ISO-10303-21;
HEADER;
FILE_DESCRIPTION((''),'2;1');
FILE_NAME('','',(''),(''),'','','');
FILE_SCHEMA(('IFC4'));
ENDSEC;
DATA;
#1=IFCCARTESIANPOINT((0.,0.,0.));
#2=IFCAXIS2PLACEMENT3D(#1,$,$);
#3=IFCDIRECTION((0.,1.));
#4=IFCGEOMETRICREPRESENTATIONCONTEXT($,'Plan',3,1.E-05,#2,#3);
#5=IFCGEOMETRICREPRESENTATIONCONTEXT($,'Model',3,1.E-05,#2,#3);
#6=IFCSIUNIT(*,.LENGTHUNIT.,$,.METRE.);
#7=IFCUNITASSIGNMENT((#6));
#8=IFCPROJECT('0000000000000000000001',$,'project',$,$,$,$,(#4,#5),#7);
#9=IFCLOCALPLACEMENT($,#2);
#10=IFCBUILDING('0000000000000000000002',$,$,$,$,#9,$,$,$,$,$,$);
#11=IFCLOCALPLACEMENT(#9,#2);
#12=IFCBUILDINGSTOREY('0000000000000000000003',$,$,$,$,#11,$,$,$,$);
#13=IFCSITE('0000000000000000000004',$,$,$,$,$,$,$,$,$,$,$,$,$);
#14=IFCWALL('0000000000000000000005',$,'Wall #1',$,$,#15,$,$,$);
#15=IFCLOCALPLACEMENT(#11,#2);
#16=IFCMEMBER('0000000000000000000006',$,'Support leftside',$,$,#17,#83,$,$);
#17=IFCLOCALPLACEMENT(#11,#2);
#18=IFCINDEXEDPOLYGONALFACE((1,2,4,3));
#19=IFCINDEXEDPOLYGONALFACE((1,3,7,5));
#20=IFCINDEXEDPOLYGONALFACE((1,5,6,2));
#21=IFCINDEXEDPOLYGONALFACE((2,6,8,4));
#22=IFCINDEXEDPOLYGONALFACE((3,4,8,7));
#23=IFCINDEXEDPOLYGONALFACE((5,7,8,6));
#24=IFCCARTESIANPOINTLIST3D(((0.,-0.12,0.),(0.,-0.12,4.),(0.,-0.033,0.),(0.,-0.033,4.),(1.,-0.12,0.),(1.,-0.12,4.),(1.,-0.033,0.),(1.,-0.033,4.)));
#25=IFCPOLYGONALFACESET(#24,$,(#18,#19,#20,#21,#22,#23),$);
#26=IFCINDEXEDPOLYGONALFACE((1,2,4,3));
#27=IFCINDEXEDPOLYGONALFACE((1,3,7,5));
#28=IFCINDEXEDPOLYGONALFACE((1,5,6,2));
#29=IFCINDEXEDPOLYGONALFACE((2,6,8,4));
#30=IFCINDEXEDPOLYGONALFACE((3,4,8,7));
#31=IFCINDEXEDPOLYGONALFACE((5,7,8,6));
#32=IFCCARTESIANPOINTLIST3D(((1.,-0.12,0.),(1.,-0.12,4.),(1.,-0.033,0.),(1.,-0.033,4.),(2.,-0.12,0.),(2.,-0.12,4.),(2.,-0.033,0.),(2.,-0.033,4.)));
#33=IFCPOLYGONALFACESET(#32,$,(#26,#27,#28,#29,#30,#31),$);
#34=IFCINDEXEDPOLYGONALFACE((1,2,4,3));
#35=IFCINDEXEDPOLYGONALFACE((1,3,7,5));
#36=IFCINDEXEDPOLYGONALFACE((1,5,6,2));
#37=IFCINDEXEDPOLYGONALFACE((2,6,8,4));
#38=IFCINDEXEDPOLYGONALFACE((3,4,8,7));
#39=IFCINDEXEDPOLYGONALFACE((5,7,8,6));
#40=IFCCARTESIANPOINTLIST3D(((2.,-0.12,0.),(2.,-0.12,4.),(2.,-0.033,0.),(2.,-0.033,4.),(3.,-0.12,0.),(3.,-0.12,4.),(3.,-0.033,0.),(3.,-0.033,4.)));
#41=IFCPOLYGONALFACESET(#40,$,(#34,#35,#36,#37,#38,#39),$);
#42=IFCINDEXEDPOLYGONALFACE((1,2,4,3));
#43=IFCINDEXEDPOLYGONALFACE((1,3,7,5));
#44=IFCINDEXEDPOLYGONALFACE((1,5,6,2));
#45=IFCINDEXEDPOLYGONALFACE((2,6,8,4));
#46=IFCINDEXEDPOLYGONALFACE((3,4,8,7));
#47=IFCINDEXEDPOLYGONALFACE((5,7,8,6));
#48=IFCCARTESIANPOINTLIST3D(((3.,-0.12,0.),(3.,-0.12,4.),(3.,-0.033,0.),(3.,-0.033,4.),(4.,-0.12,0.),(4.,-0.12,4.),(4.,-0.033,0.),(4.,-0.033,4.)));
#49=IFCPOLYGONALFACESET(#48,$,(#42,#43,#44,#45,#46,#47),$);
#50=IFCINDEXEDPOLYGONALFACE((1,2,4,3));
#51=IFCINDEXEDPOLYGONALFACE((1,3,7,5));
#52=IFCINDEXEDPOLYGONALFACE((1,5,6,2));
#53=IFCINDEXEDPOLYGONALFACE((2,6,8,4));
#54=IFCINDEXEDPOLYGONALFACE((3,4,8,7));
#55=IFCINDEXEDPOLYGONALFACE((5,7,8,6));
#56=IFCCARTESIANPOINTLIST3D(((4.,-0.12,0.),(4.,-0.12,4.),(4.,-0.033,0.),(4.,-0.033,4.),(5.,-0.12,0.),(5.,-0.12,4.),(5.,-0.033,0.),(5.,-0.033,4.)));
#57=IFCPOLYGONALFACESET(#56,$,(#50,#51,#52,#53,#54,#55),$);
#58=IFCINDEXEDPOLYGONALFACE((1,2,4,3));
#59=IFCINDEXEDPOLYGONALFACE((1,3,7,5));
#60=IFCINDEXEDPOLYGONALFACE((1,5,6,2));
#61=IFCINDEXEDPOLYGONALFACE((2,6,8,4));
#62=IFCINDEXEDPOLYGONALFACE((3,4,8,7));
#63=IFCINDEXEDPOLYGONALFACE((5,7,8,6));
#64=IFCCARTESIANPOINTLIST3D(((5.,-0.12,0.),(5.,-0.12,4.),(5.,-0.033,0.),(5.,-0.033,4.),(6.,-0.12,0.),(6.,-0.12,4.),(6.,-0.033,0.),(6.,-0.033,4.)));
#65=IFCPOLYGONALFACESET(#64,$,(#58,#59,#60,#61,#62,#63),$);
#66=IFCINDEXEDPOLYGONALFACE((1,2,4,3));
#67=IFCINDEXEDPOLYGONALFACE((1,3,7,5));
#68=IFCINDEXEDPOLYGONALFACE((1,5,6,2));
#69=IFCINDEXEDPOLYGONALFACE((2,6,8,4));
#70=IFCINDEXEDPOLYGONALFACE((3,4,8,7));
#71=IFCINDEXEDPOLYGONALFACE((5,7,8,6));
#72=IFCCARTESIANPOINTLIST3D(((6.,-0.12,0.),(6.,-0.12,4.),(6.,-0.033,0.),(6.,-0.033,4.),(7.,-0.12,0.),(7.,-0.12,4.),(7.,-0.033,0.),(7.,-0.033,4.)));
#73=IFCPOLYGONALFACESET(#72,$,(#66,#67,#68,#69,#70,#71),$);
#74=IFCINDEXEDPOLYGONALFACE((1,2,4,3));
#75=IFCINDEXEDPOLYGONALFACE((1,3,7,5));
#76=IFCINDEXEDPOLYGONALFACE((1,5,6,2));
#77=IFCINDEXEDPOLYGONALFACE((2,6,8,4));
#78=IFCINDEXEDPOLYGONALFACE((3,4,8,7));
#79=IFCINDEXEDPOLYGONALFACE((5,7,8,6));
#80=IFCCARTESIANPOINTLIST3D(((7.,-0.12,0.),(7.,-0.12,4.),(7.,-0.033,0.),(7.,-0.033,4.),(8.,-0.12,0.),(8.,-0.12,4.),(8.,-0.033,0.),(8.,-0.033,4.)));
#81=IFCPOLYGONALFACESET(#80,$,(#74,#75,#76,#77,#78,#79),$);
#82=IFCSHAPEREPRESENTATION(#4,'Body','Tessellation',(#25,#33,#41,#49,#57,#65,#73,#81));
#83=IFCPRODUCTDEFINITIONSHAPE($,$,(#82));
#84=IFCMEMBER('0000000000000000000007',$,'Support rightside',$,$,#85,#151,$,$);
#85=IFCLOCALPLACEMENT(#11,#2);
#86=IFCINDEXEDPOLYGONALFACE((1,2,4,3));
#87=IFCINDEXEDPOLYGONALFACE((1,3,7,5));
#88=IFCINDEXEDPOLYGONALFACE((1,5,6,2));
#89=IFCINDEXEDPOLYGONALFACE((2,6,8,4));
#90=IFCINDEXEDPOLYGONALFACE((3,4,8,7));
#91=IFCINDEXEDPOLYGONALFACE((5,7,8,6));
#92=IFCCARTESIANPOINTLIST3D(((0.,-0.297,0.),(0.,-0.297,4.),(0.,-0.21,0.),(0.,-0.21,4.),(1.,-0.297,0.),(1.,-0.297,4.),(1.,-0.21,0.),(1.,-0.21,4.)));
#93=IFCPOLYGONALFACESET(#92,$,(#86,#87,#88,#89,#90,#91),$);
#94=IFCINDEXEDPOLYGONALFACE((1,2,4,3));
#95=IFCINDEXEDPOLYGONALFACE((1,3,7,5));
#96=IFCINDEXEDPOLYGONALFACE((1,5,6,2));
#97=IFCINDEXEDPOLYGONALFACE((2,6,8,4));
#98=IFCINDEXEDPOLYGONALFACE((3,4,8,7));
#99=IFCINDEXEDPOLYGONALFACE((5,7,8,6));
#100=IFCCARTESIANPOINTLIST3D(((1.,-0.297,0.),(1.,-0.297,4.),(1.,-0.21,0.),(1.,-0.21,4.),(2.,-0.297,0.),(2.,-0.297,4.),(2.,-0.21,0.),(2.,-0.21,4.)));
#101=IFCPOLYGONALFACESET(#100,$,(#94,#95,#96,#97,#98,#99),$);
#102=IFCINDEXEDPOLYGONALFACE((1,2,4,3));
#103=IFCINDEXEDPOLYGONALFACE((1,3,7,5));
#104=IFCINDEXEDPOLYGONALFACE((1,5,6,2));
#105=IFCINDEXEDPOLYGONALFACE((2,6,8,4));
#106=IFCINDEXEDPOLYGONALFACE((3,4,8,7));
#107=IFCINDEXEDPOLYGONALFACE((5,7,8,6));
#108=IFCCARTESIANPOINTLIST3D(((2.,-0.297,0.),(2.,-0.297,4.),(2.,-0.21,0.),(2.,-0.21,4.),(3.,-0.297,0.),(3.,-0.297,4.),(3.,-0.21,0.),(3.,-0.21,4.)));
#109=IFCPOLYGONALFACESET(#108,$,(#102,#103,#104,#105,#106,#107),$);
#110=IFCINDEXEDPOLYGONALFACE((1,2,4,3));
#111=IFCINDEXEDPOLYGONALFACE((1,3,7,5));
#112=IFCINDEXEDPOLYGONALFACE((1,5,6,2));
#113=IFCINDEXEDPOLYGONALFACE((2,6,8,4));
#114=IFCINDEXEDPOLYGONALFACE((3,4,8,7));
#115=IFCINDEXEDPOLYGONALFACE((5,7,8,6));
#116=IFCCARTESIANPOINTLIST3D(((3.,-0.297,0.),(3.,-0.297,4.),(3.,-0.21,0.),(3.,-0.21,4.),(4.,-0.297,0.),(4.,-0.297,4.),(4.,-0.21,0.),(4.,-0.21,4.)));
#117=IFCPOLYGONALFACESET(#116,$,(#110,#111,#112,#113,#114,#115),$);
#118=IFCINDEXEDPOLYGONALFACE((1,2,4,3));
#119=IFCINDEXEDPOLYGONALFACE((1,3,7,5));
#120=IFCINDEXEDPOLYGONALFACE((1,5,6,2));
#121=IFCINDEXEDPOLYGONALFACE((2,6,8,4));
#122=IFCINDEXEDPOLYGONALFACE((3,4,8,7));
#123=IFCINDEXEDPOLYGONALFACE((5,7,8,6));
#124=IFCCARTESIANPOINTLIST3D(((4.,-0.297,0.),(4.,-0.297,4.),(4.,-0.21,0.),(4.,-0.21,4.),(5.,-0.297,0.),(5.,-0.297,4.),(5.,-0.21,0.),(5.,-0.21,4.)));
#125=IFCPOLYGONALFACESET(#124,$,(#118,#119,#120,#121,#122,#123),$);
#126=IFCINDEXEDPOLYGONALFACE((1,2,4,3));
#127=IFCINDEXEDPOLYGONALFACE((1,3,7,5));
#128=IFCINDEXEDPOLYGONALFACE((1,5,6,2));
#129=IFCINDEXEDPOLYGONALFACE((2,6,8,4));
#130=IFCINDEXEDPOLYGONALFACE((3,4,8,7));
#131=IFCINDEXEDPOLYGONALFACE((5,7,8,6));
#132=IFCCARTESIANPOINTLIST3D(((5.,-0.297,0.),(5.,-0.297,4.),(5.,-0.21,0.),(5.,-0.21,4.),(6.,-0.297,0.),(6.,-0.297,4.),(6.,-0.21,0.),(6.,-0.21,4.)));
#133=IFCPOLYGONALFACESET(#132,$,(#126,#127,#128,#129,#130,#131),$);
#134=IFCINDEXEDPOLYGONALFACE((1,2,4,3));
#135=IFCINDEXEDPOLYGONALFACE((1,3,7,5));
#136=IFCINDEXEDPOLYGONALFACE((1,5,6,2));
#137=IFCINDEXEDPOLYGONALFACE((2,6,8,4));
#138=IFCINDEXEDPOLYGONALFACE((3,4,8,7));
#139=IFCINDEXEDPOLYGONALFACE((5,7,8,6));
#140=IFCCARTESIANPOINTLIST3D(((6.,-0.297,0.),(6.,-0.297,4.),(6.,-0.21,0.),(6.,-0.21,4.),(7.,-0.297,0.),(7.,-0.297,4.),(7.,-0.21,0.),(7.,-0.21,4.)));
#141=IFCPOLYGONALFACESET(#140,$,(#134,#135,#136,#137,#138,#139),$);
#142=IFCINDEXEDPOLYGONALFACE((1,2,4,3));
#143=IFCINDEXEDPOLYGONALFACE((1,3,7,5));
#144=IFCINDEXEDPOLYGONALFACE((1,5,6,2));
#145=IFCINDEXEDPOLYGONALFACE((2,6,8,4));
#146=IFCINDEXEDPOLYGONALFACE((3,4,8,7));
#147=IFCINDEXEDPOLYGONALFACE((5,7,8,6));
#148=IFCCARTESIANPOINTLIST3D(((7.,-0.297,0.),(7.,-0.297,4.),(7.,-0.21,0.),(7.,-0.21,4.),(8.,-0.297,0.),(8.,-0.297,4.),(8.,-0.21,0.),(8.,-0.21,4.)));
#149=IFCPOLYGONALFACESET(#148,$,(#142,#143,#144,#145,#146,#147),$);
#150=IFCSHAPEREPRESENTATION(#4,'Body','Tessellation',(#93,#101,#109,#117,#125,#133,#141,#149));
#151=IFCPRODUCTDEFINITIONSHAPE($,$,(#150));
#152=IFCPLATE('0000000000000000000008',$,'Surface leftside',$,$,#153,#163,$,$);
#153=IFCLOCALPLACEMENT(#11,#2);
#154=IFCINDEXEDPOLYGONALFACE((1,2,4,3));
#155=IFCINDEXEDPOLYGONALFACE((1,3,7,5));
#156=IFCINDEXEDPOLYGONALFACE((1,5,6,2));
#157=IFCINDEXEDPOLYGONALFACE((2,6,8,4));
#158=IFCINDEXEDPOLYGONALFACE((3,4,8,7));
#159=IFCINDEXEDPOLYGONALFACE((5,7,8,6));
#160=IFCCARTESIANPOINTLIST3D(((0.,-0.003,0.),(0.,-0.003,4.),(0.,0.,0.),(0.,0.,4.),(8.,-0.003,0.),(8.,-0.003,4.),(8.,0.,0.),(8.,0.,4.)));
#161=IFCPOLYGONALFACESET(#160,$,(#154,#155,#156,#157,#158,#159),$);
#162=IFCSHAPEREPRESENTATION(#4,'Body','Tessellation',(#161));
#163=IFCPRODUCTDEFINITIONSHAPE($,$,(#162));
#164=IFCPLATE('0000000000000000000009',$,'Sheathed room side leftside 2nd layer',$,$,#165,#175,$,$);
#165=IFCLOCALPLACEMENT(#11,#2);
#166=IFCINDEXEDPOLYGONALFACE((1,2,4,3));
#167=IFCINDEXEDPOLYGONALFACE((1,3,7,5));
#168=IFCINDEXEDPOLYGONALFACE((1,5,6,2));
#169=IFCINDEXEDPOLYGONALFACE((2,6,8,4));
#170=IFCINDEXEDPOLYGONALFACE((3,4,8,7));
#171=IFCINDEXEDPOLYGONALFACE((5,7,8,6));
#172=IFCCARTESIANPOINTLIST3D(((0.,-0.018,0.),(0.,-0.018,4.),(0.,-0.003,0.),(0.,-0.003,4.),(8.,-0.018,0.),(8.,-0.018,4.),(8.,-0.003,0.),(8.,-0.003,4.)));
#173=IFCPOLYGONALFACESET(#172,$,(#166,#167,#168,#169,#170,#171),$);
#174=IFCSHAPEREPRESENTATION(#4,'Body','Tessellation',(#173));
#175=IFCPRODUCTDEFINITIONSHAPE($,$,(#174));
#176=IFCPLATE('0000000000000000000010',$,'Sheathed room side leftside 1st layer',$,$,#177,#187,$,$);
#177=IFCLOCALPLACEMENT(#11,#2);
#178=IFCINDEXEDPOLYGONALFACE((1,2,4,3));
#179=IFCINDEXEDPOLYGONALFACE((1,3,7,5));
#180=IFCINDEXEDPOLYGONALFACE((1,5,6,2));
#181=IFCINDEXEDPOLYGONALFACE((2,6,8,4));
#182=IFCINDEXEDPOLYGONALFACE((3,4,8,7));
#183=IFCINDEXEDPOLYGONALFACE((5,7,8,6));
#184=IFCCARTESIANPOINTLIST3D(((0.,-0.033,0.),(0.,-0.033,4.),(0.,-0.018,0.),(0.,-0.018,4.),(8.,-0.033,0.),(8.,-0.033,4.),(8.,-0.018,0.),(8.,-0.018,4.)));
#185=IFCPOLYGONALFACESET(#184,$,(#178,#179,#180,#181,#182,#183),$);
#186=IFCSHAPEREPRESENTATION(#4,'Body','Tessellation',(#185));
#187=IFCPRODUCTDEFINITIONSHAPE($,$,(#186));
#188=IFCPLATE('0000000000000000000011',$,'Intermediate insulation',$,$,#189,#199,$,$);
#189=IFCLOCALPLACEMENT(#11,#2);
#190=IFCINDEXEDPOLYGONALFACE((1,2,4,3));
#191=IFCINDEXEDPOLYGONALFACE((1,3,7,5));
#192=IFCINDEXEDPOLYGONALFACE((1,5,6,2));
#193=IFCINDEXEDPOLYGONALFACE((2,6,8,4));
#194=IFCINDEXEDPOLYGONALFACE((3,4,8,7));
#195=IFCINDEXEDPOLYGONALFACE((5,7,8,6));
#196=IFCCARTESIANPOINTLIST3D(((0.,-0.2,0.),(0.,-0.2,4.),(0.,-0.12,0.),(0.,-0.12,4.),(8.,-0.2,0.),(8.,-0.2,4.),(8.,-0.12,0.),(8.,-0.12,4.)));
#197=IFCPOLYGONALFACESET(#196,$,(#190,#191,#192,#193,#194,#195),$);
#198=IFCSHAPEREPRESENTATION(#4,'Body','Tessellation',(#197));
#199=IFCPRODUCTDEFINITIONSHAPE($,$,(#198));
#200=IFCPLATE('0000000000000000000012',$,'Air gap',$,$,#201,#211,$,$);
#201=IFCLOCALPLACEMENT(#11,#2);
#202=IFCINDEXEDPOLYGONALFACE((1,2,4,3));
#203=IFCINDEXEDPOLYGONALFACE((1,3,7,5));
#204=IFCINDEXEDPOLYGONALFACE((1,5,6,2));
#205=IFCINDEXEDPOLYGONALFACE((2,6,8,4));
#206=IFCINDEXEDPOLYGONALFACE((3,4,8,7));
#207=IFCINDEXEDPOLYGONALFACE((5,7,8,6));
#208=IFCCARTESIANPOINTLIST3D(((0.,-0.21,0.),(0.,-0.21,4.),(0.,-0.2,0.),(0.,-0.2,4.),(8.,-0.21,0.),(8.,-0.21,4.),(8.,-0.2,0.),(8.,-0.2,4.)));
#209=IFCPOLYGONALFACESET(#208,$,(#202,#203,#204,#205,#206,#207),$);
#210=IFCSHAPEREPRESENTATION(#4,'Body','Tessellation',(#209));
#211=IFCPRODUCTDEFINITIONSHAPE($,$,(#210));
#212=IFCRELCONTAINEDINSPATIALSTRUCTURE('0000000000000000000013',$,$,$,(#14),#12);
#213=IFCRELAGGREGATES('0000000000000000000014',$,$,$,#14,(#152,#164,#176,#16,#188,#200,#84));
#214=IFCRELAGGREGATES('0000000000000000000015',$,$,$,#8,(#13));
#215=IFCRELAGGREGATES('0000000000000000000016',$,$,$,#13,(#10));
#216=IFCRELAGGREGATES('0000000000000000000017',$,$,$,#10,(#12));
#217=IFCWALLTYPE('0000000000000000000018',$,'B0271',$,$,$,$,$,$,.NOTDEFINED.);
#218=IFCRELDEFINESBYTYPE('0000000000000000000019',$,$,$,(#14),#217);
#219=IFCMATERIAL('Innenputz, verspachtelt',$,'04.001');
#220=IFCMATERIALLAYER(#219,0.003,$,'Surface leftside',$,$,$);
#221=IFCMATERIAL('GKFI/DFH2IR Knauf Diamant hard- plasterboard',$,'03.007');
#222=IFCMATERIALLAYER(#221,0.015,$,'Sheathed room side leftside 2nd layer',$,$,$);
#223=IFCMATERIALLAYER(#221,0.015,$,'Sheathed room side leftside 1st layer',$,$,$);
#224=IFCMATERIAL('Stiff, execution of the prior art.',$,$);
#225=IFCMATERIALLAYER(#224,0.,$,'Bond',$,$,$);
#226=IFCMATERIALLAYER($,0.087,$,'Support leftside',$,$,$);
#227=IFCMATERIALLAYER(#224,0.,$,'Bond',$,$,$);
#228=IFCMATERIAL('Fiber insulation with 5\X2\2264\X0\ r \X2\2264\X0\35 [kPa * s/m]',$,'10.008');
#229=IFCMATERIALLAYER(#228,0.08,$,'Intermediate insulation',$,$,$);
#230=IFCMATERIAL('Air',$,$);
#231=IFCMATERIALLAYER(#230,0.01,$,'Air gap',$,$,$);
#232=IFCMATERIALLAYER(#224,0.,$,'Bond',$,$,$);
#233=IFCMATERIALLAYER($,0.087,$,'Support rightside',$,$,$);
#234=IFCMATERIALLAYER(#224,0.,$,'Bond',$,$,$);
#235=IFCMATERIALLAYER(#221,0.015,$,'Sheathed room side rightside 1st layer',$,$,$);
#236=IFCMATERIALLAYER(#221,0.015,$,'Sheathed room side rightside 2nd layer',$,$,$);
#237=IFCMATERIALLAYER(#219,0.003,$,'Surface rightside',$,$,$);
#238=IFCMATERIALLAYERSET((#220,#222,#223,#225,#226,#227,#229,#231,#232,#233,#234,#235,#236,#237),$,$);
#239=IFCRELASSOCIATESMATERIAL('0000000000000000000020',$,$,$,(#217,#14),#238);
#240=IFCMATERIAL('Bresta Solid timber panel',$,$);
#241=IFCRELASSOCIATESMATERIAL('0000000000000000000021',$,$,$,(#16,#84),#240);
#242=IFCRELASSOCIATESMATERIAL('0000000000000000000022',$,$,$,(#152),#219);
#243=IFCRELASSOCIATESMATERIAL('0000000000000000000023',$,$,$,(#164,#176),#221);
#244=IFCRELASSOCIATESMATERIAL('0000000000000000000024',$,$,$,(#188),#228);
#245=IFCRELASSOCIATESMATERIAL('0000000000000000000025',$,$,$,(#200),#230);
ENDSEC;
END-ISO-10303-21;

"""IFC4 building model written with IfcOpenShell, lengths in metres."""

from ifc_helpers import new_model, si_unit, direction, frame, frame_2d, origin, origin_with_axes, place, context, project, spatial, rectangle, extrude, material, layer, layer_set, type_object, element, aggregate, save


model = new_model("IFC4")

# Units and contexts
plan_context = context("Plan", 3, precision=1e-05, world=origin(), true_north=direction((0.0, 1.0)))
model_context = context("Model", 3, precision=1e-05, world=origin(), true_north=direction((0.0, 1.0)))
ifc_project = project(units=[si_unit("LENGTHUNIT", "METRE")], contexts=[plan_context, model_context])

# Site, building, storey
site = spatial("IfcSite", under=ifc_project)
building_placement = place(None, origin())
building = spatial("IfcBuilding", under=site, at=building_placement)
storey_placement = place(building_placement, origin())
storey = spatial("IfcBuildingStorey", under=building, at=storey_placement)

# Wall, members, plates
ifc_material_1 = material(Name="Innenputz, verspachtelt", Category="04.001")
ifc_layer_1 = layer(ifc_material_1, 0.003, Name="Surface leftside")
ifc_material_2 = material(Name="GKFI/DFH2IR Knauf Diamant hard- plasterboard", Category="03.007")
ifc_layer_2 = layer(ifc_material_2, 0.015, Name="Sheathed room side leftside 2nd layer")
ifc_layer_3 = layer(ifc_material_2, 0.015, Name="Sheathed room side leftside 1st layer")
ifc_material_3 = material(Name="Stiff, execution of the prior art.")
ifc_layer_4 = layer(ifc_material_3, 0.0, Name="Bond")
ifc_layer_5 = layer(None, 0.087, Name="Support leftside")
ifc_layer_6 = layer(ifc_material_3, 0.0, Name="Bond")
ifc_material_4 = material(Name="Fiber insulation with 5≤ r ≤35 [kPa * s/m]", Category="10.008")
ifc_layer_7 = layer(ifc_material_4, 0.08, Name="Intermediate insulation")
ifc_material_5 = material(Name="Air")
ifc_layer_8 = layer(ifc_material_5, 0.01, Name="Air gap")
ifc_layer_9 = layer(ifc_material_3, 0.0, Name="Bond")
ifc_layer_10 = layer(None, 0.087, Name="Support rightside")
ifc_layer_11 = layer(ifc_material_3, 0.0, Name="Bond")
ifc_layer_12 = layer(ifc_material_2, 0.015, Name="Sheathed room side rightside 1st layer")
ifc_layer_13 = layer(ifc_material_2, 0.015, Name="Sheathed room side rightside 2nd layer")
ifc_layer_14 = layer(ifc_material_1, 0.003, Name="Surface rightside")
ifc_layer_set = layer_set([ifc_layer_1, ifc_layer_2, ifc_layer_3, ifc_layer_4, ifc_layer_5, ifc_layer_6, ifc_layer_7, ifc_layer_8, ifc_layer_9, ifc_layer_10, ifc_layer_11, ifc_layer_12, ifc_layer_13, ifc_layer_14])
wall_type = type_object("IfcWallType", Name="B0271", PredefinedType="NOTDEFINED", material=ifc_layer_set)
wall_placement = place(None, frame((0.0, 0.0, 0.0), z_axis=(0.0, -1.0, 0.0), x_axis=(1.0, 0.0, 0.0)))
wall = element("IfcWall", 1, at=wall_placement, inside=storey, type_object=wall_type, material=ifc_layer_set, Name="Wall #1")
ifc_material_6 = material(Name="Bresta Solid timber panel")
member_1_placement = place(wall_placement, origin())
member_1 = element("IfcMember", 2, at=member_1_placement, material=ifc_material_6, Name="Support leftside", context=plan_context, shape_type="SweptSolid", body=[
    extrude(rectangle(XDim=1.0, YDim=0.087, at=frame_2d((0.5, 0.0435), x_axis=(1.0, 0.0))), frame((0.0, 4.0, 0.033), z_axis=(0.0, -1.0, 0.0), x_axis=(1.0, 0.0, 0.0)), (0.0, 0.0, 1.0), 4.0),
    extrude(rectangle(XDim=1.0, YDim=0.087, at=frame_2d((0.5, 0.0435), x_axis=(1.0, 0.0))), frame((1.0, 4.0, 0.033), z_axis=(0.0, -1.0, 0.0), x_axis=(1.0, 0.0, 0.0)), (0.0, 0.0, 1.0), 4.0),
    extrude(rectangle(XDim=1.0, YDim=0.087, at=frame_2d((0.5, 0.0435), x_axis=(1.0, 0.0))), frame((2.0, 4.0, 0.033), z_axis=(0.0, -1.0, 0.0), x_axis=(1.0, 0.0, 0.0)), (0.0, 0.0, 1.0), 4.0),
    extrude(rectangle(XDim=1.0, YDim=0.087, at=frame_2d((0.5, 0.0435), x_axis=(1.0, 0.0))), frame((3.0, 4.0, 0.033), z_axis=(0.0, -1.0, 0.0), x_axis=(1.0, 0.0, 0.0)), (0.0, 0.0, 1.0), 4.0),
    extrude(rectangle(XDim=1.0, YDim=0.087, at=frame_2d((0.5, 0.0435), x_axis=(1.0, 0.0))), frame((4.0, 4.0, 0.033), z_axis=(0.0, -1.0, 0.0), x_axis=(1.0, 0.0, 0.0)), (0.0, 0.0, 1.0), 4.0),
    extrude(rectangle(XDim=1.0, YDim=0.087, at=frame_2d((0.5, 0.0435), x_axis=(1.0, 0.0))), frame((5.0, 4.0, 0.033), z_axis=(0.0, -1.0, 0.0), x_axis=(1.0, 0.0, 0.0)), (0.0, 0.0, 1.0), 4.0),
    extrude(rectangle(XDim=1.0, YDim=0.087, at=frame_2d((0.5, 0.0435), x_axis=(1.0, 0.0))), frame((6.0, 4.0, 0.033), z_axis=(0.0, -1.0, 0.0), x_axis=(1.0, 0.0, 0.0)), (0.0, 0.0, 1.0), 4.0),
    extrude(rectangle(XDim=1.0, YDim=0.087, at=frame_2d((0.5, 0.0435), x_axis=(1.0, 0.0))), frame((7.0, 4.0, 0.033), z_axis=(0.0, -1.0, 0.0), x_axis=(1.0, 0.0, 0.0)), (0.0, 0.0, 1.0), 4.0),
])
member_2_placement = place(wall_placement, origin())
member_2 = element("IfcMember", 3, at=member_2_placement, material=ifc_material_6, Name="Support rightside", context=plan_context, shape_type="SweptSolid", body=[
    extrude(rectangle(XDim=1.0, YDim=0.087, at=frame_2d((0.5, 0.0435), x_axis=(1.0, 0.0))), frame((0.0, 4.0, 0.21), z_axis=(0.0, -1.0, 0.0), x_axis=(1.0, 0.0, 0.0)), (0.0, 0.0, 1.0), 4.0),
    extrude(rectangle(XDim=1.0, YDim=0.087, at=frame_2d((0.5, 0.0435), x_axis=(1.0, 0.0))), frame((1.0, 4.0, 0.21), z_axis=(0.0, -1.0, 0.0), x_axis=(1.0, 0.0, 0.0)), (0.0, 0.0, 1.0), 4.0),
    extrude(rectangle(XDim=1.0, YDim=0.087, at=frame_2d((0.5, 0.0435), x_axis=(1.0, 0.0))), frame((2.0, 4.0, 0.21), z_axis=(0.0, -1.0, 0.0), x_axis=(1.0, 0.0, 0.0)), (0.0, 0.0, 1.0), 4.0),
    extrude(rectangle(XDim=1.0, YDim=0.087, at=frame_2d((0.5, 0.0435), x_axis=(1.0, 0.0))), frame((3.0, 4.0, 0.21), z_axis=(0.0, -1.0, 0.0), x_axis=(1.0, 0.0, 0.0)), (0.0, 0.0, 1.0), 4.0),
    extrude(rectangle(XDim=1.0, YDim=0.087, at=frame_2d((0.5, 0.0435), x_axis=(1.0, 0.0))), frame((4.0, 4.0, 0.21), z_axis=(0.0, -1.0, 0.0), x_axis=(1.0, 0.0, 0.0)), (0.0, 0.0, 1.0), 4.0),
    extrude(rectangle(XDim=1.0, YDim=0.087, at=frame_2d((0.5, 0.0435), x_axis=(1.0, 0.0))), frame((5.0, 4.0, 0.21), z_axis=(0.0, -1.0, 0.0), x_axis=(1.0, 0.0, 0.0)), (0.0, 0.0, 1.0), 4.0),
    extrude(rectangle(XDim=1.0, YDim=0.087, at=frame_2d((0.5, 0.0435), x_axis=(1.0, 0.0))), frame((6.0, 4.0, 0.21), z_axis=(0.0, -1.0, 0.0), x_axis=(1.0, 0.0, 0.0)), (0.0, 0.0, 1.0), 4.0),
    extrude(rectangle(XDim=1.0, YDim=0.087, at=frame_2d((0.5, 0.0435), x_axis=(1.0, 0.0))), frame((7.0, 4.0, 0.21), z_axis=(0.0, -1.0, 0.0), x_axis=(1.0, 0.0, 0.0)), (0.0, 0.0, 1.0), 4.0),
])
plate_1_placement = place(wall_placement, origin())
plate_1 = element("IfcPlate", 4, at=plate_1_placement, material=ifc_material_1, Name="Surface leftside", context=plan_context, shape_type="SweptSolid", body=[
    extrude(rectangle(XDim=8.0, YDim=4.0, at=frame_2d((4.0, 2.0), x_axis=(1.0, 0.0))), origin_with_axes(), (0.0, 0.0, 1.0), 0.003),
])
plate_2_placement = place(wall_placement, origin())
plate_2 = element("IfcPlate", 5, at=plate_2_placement, material=ifc_material_2, Name="Sheathed room side leftside 2nd layer", context=plan_context, shape_type="SweptSolid", body=[
    extrude(rectangle(XDim=8.0, YDim=4.0, at=frame_2d((4.0, 2.0), x_axis=(1.0, 0.0))), frame((0.0, 0.0, 0.003), z_axis=(0.0, 0.0, 1.0), x_axis=(1.0, 0.0, 0.0)), (0.0, 0.0, 1.0), 0.015),
])
plate_3_placement = place(wall_placement, origin())
plate_3 = element("IfcPlate", 6, at=plate_3_placement, material=ifc_material_2, Name="Sheathed room side leftside 1st layer", context=plan_context, shape_type="SweptSolid", body=[
    extrude(rectangle(XDim=8.0, YDim=4.0, at=frame_2d((4.0, 2.0), x_axis=(1.0, 0.0))), frame((0.0, 0.0, 0.018), z_axis=(0.0, 0.0, 1.0), x_axis=(1.0, 0.0, 0.0)), (0.0, 0.0, 1.0), 0.015),
])
plate_4_placement = place(wall_placement, origin())
plate_4 = element("IfcPlate", 7, at=plate_4_placement, material=ifc_material_4, Name="Intermediate insulation", context=plan_context, shape_type="SweptSolid", body=[
    extrude(rectangle(XDim=8.0, YDim=4.0, at=frame_2d((4.0, 2.0), x_axis=(1.0, 0.0))), frame((0.0, 0.0, 0.12), z_axis=(0.0, 0.0, 1.0), x_axis=(1.0, 0.0, 0.0)), (0.0, 0.0, 1.0), 0.08),
])
plate_5_placement = place(wall_placement, origin())
plate_5 = element("IfcPlate", 8, at=plate_5_placement, material=ifc_material_5, Name="Air gap", context=plan_context, shape_type="SweptSolid", body=[
    extrude(rectangle(XDim=8.0, YDim=4.0, at=frame_2d((4.0, 2.0), x_axis=(1.0, 0.0))), frame((0.0, 0.0, 0.2), z_axis=(0.0, 0.0, 1.0), x_axis=(1.0, 0.0, 0.0)), (0.0, 0.0, 1.0), 0.01),
])
aggregate(wall, [plate_1, plate_2, plate_3, member_1, plate_4, plate_5, member_2])

save(model, "model.ifc")
